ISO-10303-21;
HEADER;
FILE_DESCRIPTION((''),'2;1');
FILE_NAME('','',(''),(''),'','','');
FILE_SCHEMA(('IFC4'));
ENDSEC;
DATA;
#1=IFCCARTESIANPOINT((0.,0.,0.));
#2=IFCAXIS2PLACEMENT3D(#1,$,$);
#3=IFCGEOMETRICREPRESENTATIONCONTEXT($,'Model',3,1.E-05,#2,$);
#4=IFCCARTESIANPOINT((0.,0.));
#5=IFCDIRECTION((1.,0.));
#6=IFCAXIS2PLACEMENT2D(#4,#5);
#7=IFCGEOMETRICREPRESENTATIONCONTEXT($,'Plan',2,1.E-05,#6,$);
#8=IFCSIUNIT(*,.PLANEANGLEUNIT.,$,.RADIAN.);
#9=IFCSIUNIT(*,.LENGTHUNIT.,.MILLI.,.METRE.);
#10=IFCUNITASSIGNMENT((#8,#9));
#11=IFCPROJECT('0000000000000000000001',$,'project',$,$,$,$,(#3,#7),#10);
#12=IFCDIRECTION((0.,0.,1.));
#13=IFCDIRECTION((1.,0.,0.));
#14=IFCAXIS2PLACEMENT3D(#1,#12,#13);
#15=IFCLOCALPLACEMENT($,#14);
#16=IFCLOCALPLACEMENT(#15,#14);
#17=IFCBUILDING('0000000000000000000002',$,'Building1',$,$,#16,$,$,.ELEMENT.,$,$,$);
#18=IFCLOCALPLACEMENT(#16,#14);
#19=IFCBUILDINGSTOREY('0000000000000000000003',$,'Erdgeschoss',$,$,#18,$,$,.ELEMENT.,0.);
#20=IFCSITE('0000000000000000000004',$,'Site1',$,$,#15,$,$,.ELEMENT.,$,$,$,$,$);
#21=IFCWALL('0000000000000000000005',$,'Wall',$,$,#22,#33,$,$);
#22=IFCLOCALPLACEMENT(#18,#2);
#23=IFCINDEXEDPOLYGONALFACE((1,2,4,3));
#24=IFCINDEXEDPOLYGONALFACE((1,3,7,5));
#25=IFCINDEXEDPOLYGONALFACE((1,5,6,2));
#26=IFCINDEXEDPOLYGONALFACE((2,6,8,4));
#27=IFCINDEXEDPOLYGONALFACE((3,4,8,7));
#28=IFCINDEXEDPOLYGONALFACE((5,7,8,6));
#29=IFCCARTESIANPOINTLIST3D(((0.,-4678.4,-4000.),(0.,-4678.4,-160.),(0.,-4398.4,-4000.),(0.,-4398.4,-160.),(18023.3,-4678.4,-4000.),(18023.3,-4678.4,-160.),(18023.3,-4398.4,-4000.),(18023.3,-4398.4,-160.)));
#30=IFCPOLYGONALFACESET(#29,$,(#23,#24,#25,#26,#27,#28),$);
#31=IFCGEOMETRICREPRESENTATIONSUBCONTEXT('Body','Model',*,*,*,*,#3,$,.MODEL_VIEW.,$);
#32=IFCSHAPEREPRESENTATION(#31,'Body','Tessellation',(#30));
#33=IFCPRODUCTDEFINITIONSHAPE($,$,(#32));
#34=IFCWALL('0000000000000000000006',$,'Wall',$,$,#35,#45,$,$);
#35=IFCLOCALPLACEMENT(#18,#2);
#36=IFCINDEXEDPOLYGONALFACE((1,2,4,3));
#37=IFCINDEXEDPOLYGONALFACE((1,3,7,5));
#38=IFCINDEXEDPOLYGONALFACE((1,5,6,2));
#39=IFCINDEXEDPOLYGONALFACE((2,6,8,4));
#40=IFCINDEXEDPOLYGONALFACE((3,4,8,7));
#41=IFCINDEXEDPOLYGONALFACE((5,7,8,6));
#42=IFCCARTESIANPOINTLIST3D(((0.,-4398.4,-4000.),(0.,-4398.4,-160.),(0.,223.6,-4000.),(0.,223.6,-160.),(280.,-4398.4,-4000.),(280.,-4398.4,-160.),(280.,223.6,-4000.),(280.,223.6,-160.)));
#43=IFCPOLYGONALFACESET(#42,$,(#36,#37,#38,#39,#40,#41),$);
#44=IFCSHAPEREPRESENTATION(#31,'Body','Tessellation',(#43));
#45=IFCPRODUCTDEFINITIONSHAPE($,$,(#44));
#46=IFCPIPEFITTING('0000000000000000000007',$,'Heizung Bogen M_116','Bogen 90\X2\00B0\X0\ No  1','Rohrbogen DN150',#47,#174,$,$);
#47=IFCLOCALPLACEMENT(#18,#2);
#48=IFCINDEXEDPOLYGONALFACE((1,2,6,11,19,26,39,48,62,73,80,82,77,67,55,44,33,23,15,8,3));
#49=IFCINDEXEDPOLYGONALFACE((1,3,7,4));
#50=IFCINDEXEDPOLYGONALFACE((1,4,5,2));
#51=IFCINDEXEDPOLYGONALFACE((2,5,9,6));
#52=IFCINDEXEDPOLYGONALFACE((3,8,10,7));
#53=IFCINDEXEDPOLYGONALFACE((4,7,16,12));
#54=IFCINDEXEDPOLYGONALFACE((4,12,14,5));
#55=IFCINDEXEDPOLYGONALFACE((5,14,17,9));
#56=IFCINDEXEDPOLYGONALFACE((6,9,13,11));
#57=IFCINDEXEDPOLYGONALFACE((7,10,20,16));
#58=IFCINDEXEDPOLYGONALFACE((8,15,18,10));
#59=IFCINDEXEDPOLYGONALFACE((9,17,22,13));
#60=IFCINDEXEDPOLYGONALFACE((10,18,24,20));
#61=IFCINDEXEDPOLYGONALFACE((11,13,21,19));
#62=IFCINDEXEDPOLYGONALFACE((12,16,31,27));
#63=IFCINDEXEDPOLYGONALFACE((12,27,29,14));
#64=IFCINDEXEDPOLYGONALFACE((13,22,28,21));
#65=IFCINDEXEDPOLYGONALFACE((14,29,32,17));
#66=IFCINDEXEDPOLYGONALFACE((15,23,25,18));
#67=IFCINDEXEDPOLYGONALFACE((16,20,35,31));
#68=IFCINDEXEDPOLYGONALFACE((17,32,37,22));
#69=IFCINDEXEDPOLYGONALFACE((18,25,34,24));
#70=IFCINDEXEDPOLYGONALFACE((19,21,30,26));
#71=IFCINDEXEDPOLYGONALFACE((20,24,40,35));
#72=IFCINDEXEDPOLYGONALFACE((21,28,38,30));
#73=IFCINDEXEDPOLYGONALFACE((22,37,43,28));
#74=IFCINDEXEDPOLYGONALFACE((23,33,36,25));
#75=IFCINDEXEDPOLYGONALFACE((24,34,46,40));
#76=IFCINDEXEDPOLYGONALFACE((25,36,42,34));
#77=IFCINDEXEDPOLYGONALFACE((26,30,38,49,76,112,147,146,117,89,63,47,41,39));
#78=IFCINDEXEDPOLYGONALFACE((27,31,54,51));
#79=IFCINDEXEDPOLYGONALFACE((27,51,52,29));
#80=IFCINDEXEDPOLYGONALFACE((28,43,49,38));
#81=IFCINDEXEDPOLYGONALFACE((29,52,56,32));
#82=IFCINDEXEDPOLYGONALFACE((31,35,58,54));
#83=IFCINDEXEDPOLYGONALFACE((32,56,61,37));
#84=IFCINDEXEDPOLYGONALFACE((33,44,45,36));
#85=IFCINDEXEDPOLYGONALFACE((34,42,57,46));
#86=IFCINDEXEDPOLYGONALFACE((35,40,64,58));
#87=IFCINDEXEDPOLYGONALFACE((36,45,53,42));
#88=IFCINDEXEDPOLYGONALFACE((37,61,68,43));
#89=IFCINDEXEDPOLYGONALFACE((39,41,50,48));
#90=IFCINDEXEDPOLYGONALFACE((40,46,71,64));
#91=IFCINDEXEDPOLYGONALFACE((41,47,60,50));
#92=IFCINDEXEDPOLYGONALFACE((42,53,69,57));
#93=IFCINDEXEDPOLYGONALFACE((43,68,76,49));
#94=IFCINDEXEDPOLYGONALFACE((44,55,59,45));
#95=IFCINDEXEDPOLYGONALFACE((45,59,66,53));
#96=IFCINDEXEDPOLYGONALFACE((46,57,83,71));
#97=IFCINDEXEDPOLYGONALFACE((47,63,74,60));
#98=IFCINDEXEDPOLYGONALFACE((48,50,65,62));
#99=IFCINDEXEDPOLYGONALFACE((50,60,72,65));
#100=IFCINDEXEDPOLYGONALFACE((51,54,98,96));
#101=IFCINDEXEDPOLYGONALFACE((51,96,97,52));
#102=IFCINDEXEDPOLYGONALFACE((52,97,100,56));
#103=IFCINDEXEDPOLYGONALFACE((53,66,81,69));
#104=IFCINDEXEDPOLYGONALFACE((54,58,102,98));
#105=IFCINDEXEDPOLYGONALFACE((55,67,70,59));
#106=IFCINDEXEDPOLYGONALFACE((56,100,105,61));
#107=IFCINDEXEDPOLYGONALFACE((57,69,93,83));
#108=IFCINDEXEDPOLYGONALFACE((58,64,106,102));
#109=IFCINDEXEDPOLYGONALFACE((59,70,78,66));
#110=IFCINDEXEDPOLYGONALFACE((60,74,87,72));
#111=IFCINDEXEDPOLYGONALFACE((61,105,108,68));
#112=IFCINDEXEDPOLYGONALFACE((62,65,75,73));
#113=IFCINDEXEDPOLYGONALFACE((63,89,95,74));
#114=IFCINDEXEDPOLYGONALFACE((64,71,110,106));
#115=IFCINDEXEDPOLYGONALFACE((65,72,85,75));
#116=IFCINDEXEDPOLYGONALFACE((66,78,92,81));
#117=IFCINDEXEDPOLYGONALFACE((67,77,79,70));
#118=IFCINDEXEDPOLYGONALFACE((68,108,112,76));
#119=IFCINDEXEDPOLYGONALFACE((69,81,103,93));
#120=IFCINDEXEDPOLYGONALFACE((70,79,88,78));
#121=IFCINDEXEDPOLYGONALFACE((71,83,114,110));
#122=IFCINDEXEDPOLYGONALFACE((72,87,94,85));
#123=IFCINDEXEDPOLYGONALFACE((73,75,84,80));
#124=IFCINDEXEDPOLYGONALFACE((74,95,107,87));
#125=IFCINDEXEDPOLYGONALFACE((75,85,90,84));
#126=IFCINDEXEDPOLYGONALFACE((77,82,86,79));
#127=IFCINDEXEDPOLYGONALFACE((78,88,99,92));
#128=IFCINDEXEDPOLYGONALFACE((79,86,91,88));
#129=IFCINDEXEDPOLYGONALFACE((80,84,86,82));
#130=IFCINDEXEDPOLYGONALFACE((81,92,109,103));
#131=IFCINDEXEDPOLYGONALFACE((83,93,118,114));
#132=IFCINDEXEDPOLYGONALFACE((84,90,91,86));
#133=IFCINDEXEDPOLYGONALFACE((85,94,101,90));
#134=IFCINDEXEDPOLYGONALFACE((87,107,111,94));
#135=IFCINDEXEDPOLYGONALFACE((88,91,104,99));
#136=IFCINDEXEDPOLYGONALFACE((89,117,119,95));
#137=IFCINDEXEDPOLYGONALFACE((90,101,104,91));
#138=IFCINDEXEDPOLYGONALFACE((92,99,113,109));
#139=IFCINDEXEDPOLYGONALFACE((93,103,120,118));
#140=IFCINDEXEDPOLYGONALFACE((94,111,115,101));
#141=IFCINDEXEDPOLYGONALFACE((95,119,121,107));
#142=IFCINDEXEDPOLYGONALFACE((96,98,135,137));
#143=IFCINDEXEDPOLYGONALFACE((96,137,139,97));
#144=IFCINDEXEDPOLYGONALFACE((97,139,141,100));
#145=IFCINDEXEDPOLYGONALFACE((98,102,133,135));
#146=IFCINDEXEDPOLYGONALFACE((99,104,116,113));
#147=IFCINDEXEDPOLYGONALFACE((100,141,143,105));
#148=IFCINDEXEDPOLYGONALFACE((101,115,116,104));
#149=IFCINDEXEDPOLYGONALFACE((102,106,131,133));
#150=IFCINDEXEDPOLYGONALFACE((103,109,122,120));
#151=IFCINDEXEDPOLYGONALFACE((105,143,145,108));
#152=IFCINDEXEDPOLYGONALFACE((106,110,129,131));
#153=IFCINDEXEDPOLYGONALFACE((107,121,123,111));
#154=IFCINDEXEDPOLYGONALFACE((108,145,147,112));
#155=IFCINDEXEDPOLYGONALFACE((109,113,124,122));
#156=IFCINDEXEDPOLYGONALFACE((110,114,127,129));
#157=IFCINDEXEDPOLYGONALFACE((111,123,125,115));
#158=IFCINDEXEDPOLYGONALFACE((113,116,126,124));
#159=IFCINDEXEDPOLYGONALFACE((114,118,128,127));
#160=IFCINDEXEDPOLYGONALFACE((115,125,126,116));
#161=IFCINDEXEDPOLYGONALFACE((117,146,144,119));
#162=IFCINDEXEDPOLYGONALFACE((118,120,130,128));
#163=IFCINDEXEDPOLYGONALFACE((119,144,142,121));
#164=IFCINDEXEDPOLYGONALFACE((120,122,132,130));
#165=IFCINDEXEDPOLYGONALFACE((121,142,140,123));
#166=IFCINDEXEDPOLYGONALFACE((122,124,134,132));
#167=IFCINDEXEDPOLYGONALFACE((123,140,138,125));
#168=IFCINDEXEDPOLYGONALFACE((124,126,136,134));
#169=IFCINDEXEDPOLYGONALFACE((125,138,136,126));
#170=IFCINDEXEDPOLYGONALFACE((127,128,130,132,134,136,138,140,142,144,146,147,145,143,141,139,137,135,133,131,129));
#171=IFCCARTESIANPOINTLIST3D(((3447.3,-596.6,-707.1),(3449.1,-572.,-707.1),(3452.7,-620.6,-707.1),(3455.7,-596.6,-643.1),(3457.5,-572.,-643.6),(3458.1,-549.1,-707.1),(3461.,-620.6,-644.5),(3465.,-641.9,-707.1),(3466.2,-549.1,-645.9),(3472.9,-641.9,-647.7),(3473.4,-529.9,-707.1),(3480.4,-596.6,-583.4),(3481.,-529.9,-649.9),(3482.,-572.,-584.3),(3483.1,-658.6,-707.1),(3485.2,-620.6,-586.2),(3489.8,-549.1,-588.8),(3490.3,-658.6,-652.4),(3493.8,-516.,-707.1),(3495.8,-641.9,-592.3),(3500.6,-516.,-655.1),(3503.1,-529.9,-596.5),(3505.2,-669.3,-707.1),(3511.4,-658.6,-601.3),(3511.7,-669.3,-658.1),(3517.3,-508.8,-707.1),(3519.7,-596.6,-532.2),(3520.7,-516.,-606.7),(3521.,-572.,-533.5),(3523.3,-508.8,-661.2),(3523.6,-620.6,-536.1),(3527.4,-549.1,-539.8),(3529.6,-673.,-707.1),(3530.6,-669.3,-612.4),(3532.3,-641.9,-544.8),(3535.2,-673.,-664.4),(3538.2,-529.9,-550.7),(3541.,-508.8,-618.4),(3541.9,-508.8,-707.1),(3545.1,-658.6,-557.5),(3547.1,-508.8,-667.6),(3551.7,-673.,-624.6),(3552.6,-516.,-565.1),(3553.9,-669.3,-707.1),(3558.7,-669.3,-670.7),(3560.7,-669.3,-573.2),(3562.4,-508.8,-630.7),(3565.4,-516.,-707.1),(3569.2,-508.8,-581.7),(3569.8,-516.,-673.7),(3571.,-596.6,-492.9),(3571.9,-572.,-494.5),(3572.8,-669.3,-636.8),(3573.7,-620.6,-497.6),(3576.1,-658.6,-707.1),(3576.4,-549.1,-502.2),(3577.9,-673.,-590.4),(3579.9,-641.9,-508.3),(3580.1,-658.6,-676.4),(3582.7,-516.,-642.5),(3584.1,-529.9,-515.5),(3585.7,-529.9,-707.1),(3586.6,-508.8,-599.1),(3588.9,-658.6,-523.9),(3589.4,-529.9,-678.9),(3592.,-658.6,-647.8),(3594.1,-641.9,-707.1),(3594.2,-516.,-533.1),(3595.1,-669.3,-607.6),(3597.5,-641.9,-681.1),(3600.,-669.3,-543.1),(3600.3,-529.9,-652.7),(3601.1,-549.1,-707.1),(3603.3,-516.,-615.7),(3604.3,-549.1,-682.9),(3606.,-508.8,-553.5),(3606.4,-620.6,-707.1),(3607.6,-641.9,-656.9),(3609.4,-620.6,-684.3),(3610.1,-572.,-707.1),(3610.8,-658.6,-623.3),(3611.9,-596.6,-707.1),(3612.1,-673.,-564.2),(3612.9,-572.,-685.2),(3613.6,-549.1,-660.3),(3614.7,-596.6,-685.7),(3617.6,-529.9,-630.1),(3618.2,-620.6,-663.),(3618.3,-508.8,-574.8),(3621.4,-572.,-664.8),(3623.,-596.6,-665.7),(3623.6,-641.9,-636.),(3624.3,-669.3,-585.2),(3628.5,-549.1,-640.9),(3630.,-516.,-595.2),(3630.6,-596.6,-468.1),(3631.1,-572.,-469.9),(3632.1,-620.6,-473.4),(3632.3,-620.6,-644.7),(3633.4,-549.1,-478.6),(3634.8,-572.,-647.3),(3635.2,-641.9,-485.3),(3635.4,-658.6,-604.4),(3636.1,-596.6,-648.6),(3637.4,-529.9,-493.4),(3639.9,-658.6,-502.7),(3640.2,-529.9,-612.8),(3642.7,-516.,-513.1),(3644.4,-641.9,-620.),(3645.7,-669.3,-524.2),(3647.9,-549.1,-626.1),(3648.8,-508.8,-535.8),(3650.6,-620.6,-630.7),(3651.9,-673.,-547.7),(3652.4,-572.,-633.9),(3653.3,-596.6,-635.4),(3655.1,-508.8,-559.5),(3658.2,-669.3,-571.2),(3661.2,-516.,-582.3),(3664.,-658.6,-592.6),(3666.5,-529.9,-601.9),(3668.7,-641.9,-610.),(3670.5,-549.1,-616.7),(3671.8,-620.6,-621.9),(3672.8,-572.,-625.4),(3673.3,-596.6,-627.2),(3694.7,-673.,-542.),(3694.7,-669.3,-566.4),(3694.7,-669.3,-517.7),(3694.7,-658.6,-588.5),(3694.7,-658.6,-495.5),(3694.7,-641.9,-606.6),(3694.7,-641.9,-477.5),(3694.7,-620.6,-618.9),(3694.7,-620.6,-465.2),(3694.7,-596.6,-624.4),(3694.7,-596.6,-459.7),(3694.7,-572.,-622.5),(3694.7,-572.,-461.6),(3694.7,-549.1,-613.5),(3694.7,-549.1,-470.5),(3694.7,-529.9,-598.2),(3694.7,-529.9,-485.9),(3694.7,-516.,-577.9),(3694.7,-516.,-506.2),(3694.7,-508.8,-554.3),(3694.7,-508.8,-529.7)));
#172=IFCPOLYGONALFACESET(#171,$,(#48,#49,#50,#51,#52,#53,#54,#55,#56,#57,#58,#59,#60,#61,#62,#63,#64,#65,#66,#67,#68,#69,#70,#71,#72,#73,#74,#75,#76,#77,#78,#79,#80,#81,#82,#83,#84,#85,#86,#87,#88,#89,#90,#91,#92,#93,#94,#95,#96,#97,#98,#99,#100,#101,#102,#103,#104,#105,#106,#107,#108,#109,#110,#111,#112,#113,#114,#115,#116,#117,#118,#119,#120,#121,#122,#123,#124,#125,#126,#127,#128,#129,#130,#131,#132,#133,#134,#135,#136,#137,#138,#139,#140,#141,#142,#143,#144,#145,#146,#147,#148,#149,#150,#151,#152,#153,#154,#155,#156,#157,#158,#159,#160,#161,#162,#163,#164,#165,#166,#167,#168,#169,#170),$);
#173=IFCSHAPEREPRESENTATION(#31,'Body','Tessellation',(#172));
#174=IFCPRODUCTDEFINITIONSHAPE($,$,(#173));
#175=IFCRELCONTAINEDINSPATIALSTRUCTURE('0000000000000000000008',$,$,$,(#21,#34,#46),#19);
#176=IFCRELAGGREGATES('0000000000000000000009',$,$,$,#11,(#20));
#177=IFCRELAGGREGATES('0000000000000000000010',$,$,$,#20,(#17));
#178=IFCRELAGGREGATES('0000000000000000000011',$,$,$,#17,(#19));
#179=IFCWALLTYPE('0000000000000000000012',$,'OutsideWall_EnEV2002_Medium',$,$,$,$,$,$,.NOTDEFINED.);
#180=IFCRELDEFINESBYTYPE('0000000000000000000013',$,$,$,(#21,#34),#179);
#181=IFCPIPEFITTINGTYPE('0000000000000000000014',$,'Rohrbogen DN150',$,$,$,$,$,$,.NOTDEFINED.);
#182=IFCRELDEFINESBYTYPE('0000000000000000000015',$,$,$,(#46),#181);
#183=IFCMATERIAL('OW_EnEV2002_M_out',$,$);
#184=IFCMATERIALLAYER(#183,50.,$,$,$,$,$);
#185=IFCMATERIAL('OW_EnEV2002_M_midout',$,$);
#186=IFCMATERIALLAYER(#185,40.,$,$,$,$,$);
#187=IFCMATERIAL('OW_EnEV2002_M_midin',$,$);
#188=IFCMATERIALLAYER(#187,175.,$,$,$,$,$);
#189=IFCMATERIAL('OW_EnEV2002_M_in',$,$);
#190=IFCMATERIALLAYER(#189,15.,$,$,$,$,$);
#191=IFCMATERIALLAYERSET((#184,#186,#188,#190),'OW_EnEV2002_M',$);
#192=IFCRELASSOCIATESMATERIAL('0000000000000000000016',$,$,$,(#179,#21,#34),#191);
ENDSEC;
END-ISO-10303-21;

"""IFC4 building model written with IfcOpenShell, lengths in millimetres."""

from ifc_helpers import new_model, entity, si_unit, frame, origin, origin_with_axes, origin_2d_with_axis, place, context, subcontext, project, spatial, indexed_curve, outline, extrude, source, transform, mapped, material, layer, layer_set, layer_usage, type_object, element, save


model = new_model("IFC4")

# Units and contexts
model_context = context("Model", 3, precision=1e-05, world=origin())
plan_context = context("Plan", 2, precision=1e-05, world=origin_2d_with_axis())
body_context = subcontext(model_context, "Body", "Model", "MODEL_VIEW")
ifc_project = project(units=[si_unit("PLANEANGLEUNIT", "RADIAN"), si_unit("LENGTHUNIT", "METRE", prefix="MILLI")], contexts=[model_context, plan_context])

# Site, building, storey
site_placement = place(None, origin_with_axes())
site = spatial("IfcSite", under=ifc_project, at=site_placement, Name="Site1", CompositionType="ELEMENT")
building_placement = place(site_placement, origin_with_axes())
building = spatial("IfcBuilding", under=site, at=building_placement, Name="Building1", CompositionType="ELEMENT")
storey_placement = place(building_placement, origin_with_axes())
storey = spatial("IfcBuildingStorey", under=building, at=storey_placement, Name="Erdgeschoss", CompositionType="ELEMENT", Elevation=0.0)

# Walls
ifc_material_1 = material(Name="OW_EnEV2002_M_out")
ifc_layer_1 = layer(ifc_material_1, 50.0)
ifc_material_2 = material(Name="OW_EnEV2002_M_midout")
ifc_layer_2 = layer(ifc_material_2, 40.0)
ifc_material_3 = material(Name="OW_EnEV2002_M_midin")
ifc_layer_3 = layer(ifc_material_3, 175.0)
ifc_material_4 = material(Name="OW_EnEV2002_M_in")
ifc_layer_4 = layer(ifc_material_4, 15.0)
ifc_layer_set = layer_set([ifc_layer_1, ifc_layer_2, ifc_layer_3, ifc_layer_4], Name="OW_EnEV2002_M")
ifc_layer_usage_1 = layer_usage(ifc_layer_set, "AXIS2", "POSITIVE", 0.0)
wall_type = type_object("IfcWallType", Name="OutsideWall_EnEV2002_Medium", PredefinedType="NOTDEFINED", material=ifc_layer_set)
wall_1_placement = place(storey_placement, frame((0.0, -4678.4, -4000.0), z_axis=(0.0, 0.0, 1.0), x_axis=(1.0, 0.0, 0.0)))
element("IfcWall", 1, at=wall_1_placement, inside=storey, type_object=wall_type, material=ifc_layer_usage_1, Name="Wall", context=body_context, shape_type="SweptSolid", body=[
    extrude(outline(indexed_curve([(0.0, 0.0), (0.0, 280.0), (18023.3, 280.0), (18023.3, 0.0), (0.0, 0.0)], self_intersect=False)), origin_with_axes(), (0.0, 0.0, 1.0), 3840.0),
])
ifc_layer_usage_2 = layer_usage(ifc_layer_set, "AXIS2", "POSITIVE", 0.0)
wall_2_placement = place(storey_placement, frame((280.0, -4398.4, -4000.0), z_axis=(0.0, 0.0, 1.0), x_axis=(0.0, 1.0, 0.0)))
element("IfcWall", 2, at=wall_2_placement, inside=storey, type_object=wall_type, material=ifc_layer_usage_2, Name="Wall", context=body_context, shape_type="SweptSolid", body=[
    extrude(outline(indexed_curve([(0.0, 0.0), (0.0, 280.0), (4622.0, 280.0), (4622.0, 0.0), (0.0, 0.0)], self_intersect=False)), origin_with_axes(), (0.0, 0.0, 1.0), 3840.0),
])

# Pipe fitting
pipe_fitting_type_1 = type_object("IfcPipeFittingType", Name="Rohrbogen DN150", PredefinedType="NOTDEFINED")
ifc_direction_1 = entity("IfcDirection", [-1.0, 0.0, 0.0])
shared_shape_1 = source(origin_with_axes(), body_context, "Body", "SolidModel", [
    entity("IfcRevolvedAreaSolid", entity("IfcCircleProfileDef", "AREA", None, entity("IfcAxis2Placement2D", entity("IfcCartesianPoint", [0.0, 0.0]), entity("IfcDirection", [1.0, 0.0])), 82.5), entity("IfcAxis2Placement3D", entity("IfcCartesianPoint", [123.8, -41.3, 0.0]), ifc_direction_1, entity("IfcDirection", [0.0, 0.0, 1.0])), entity("IfcAxis1Placement", entity("IfcCartesianPoint", [0.0, 165.1, 0.0]), ifc_direction_1), 1.570796),
])
pipe_fitting_1_placement = place(storey_placement, frame((3570.9, -590.4, -583.3), z_axis=(0.0, 0.0, 1.0), x_axis=(1.0, 0.0, 0.0)))
element("IfcPipeFitting", 3, at=pipe_fitting_1_placement, inside=storey, type_object=pipe_fitting_type_1, Name="Heizung Bogen M_116", Description="Bogen 90° No  1", ObjectType="Rohrbogen DN150", context=body_context, shape_type="MappedRepresentation", body=[
    mapped(shared_shape_1, transform((0.0, 0.0, 0.0), x_axis=(0.0, 0.0, -1.0), y_axis=(1.0, 0.0, 0.0), z_axis=(0.0, -1.0, 0.0), scale=1.0)),
])

save(model, "model.ifc")
